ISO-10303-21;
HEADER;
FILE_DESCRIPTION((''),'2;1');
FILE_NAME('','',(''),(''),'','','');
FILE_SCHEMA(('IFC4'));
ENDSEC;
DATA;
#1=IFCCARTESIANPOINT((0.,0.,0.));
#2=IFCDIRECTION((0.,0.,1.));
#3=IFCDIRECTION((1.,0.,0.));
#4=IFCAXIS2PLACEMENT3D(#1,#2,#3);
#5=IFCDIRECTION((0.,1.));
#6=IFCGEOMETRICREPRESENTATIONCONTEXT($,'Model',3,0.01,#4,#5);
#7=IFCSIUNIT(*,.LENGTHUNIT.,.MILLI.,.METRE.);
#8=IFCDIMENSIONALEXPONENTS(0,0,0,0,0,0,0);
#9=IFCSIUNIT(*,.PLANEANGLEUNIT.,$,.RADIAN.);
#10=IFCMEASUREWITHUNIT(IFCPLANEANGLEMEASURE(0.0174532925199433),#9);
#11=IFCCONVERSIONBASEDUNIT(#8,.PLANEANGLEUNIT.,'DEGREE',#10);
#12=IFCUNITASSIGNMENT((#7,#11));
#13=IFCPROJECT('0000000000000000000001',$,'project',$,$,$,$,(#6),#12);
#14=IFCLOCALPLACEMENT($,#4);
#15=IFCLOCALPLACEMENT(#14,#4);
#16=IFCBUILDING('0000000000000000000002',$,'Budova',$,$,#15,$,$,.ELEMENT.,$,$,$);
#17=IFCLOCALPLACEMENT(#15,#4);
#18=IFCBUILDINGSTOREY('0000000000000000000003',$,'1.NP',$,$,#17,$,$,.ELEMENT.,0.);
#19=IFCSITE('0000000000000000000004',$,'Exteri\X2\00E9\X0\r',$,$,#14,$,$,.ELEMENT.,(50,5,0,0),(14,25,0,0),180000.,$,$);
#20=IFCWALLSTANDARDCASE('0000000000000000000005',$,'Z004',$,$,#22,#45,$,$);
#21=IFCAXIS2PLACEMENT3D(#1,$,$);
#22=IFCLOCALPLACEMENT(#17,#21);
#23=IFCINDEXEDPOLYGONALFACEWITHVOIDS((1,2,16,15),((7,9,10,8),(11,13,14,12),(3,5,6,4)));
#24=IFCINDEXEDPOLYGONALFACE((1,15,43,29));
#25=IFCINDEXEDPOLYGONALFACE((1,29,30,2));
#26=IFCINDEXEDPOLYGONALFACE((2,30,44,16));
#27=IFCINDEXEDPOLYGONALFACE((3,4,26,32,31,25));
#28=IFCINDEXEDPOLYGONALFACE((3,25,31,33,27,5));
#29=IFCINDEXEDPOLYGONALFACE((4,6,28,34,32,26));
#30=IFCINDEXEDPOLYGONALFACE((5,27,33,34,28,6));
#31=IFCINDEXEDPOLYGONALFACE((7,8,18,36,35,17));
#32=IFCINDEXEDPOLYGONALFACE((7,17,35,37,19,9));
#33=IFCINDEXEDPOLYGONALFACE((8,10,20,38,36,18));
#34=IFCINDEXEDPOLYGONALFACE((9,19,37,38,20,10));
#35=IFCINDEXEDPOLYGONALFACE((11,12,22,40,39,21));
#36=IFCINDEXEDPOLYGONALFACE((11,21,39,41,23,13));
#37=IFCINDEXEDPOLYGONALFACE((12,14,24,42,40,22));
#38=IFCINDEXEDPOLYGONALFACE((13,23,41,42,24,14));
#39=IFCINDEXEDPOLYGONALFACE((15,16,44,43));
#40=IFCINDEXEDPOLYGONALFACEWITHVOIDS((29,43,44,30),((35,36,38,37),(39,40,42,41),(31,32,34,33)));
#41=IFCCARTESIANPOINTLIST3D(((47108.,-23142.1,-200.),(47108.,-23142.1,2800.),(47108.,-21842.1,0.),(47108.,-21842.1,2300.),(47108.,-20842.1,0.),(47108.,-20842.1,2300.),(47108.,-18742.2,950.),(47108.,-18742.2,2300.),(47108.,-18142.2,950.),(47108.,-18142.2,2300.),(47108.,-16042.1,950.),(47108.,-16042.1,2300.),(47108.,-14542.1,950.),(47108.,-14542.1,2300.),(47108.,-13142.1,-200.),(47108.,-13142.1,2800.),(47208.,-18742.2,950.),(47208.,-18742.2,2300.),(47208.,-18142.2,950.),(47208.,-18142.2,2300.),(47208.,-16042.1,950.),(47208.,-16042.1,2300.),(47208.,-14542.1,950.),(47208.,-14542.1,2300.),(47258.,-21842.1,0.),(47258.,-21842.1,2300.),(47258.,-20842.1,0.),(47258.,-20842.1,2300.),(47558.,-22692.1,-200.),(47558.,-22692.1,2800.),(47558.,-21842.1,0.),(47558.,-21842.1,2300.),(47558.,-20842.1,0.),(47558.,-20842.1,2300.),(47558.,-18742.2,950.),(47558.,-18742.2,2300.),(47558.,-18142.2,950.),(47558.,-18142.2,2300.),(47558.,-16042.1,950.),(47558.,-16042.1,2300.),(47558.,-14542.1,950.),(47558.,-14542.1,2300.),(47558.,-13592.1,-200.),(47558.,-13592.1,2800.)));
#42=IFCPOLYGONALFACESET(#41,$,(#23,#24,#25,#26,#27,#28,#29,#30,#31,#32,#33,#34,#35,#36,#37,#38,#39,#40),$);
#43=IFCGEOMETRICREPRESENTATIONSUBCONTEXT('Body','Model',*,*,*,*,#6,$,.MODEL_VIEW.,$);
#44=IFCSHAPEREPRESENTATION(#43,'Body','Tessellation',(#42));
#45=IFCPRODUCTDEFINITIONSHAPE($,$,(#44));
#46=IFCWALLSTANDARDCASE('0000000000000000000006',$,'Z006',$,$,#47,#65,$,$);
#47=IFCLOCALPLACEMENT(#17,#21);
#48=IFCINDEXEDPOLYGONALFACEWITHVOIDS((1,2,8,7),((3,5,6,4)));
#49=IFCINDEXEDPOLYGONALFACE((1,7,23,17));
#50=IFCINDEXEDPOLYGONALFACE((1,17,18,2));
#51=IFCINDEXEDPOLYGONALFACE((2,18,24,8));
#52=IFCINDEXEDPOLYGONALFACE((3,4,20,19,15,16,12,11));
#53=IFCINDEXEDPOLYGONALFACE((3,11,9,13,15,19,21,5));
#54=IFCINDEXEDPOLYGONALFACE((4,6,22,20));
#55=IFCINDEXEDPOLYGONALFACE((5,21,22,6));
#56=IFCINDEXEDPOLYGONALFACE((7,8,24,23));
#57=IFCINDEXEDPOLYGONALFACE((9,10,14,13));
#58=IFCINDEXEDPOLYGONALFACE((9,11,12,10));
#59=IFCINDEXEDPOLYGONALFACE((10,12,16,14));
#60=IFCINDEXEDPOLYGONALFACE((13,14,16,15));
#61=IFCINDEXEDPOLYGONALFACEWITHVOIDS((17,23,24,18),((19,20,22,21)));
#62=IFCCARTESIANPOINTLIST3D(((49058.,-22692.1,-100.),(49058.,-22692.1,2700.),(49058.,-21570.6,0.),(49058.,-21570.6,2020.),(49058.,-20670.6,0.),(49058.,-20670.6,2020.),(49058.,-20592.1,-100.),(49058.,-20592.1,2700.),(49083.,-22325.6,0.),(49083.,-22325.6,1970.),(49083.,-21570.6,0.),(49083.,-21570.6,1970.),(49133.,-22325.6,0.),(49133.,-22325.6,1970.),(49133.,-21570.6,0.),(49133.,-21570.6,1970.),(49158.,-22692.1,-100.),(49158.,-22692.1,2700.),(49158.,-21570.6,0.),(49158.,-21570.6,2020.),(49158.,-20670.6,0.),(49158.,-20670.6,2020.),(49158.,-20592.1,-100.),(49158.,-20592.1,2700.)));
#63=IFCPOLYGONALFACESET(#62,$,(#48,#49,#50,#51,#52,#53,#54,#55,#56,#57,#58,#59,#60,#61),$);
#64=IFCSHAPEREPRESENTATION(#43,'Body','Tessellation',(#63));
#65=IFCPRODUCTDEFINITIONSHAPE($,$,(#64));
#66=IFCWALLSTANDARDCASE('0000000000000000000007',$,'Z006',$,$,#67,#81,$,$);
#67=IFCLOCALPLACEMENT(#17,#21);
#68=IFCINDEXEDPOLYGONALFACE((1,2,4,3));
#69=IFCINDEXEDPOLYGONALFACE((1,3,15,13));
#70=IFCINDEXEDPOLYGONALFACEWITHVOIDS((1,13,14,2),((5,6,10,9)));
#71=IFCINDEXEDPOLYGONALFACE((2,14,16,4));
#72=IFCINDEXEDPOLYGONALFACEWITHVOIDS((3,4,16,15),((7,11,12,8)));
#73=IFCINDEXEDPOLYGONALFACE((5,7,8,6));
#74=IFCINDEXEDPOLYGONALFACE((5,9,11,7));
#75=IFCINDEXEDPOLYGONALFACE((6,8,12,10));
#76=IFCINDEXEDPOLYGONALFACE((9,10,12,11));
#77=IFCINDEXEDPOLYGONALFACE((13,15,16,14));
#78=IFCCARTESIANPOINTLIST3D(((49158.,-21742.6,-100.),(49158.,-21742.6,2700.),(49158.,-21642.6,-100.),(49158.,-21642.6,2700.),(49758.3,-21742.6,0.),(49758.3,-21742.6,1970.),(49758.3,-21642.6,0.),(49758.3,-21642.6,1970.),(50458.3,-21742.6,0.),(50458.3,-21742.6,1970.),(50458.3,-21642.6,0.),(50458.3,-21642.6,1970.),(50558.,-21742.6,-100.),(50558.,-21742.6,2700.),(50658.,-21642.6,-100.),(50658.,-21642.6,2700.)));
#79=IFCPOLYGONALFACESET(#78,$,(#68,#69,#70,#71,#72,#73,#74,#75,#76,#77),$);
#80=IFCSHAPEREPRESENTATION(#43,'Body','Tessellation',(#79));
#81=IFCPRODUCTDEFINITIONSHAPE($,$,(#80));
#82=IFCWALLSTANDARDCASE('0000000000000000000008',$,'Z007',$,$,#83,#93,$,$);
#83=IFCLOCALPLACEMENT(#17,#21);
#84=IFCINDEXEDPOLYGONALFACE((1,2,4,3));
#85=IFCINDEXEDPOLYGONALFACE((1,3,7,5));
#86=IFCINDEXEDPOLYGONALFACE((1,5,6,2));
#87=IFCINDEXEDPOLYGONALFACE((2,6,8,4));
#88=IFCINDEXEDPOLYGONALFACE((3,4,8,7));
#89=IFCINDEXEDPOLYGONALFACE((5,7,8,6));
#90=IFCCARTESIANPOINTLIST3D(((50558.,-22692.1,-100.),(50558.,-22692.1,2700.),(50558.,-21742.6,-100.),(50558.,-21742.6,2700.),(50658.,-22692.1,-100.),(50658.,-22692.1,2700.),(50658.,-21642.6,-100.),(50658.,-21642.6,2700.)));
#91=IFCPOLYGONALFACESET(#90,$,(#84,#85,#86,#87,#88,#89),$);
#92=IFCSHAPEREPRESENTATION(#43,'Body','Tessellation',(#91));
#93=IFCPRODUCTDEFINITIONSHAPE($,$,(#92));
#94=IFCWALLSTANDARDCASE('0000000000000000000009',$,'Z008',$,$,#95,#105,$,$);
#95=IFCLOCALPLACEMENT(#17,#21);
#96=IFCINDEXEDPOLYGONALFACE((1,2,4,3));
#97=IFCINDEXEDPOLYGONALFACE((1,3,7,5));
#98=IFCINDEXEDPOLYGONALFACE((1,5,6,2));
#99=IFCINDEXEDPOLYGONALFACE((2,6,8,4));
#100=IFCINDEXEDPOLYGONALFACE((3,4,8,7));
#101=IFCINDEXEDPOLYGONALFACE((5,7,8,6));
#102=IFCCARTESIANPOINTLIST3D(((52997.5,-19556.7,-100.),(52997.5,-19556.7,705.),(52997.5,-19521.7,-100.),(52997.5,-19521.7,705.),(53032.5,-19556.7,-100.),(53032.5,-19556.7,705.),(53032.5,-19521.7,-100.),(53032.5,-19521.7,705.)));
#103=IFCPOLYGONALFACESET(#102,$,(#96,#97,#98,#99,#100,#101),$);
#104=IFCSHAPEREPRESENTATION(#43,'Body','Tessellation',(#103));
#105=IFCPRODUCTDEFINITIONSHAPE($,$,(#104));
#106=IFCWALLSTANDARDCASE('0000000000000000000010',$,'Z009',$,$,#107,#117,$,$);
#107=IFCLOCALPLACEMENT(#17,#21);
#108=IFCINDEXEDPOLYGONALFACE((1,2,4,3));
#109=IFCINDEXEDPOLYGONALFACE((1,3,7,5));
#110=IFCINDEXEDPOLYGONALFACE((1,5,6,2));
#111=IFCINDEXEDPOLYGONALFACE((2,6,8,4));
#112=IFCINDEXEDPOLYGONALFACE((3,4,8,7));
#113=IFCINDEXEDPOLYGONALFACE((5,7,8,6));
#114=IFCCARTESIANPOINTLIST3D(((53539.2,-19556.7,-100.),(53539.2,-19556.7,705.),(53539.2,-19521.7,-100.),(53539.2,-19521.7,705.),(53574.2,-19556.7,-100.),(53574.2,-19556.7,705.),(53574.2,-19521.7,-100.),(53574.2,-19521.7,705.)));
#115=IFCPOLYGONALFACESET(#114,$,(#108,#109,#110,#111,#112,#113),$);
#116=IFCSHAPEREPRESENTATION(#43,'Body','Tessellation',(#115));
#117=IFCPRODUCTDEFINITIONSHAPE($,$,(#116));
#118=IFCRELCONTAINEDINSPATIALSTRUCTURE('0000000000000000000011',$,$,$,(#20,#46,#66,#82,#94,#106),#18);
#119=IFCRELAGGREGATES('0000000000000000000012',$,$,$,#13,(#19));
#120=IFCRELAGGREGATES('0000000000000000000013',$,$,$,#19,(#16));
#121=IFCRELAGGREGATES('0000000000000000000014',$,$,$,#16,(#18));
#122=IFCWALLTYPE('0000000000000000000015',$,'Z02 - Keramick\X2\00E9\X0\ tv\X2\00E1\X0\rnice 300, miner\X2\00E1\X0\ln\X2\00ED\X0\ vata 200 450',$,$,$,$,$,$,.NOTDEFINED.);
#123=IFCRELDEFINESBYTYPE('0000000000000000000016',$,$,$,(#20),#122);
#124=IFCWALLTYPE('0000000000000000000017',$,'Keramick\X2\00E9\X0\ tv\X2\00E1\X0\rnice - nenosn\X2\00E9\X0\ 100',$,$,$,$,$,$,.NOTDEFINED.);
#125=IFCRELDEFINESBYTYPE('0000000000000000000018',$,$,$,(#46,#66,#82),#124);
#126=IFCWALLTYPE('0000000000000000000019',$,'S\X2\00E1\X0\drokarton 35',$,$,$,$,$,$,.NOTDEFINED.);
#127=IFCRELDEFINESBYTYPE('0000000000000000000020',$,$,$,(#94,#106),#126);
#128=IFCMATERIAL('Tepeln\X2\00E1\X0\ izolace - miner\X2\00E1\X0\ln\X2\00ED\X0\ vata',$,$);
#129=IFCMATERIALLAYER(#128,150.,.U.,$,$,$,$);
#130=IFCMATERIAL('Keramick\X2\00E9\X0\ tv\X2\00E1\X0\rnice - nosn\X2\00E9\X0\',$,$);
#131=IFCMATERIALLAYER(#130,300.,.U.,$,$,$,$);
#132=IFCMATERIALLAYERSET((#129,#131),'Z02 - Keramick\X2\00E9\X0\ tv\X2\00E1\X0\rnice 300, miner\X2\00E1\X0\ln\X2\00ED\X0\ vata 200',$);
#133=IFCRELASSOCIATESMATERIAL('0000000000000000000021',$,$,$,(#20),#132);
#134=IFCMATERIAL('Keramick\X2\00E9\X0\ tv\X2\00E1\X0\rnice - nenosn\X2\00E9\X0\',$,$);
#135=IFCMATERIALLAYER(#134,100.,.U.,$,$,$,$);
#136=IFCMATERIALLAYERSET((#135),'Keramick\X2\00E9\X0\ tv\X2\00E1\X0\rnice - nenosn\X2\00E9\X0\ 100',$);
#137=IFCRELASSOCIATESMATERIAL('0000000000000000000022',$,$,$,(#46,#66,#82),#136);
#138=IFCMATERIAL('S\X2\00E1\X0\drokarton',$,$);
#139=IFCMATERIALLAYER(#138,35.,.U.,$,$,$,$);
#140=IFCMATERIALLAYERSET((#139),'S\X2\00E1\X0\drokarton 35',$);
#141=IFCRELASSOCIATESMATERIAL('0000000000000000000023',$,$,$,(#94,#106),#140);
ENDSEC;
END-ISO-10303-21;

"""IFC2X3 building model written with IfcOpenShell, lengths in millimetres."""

from ifc_helpers import new_model, entity, si_unit, converted_unit, direction, frame, origin_with_axes, origin_2d_with_axis, place, context, subcontext, project, spatial, polyline, rectangle, outline, extrude, material, layer, layer_set, layer_usage, type_object, element, save


model = new_model("IFC2X3")

# Units and contexts
model_context = context("Model", 3, precision=0.01, world=origin_with_axes(), true_north=direction((0.0, 1.0)))
body_context = subcontext(model_context, "Body", "Model", "MODEL_VIEW")
ifc_project = project(units=[si_unit("LENGTHUNIT", "METRE", prefix="MILLI"), converted_unit("PLANEANGLEUNIT", "DEGREE", entity("IfcPlaneAngleMeasure", 0.0174532925199433), si_unit("PLANEANGLEUNIT", "RADIAN"), dimensions=[0, 0, 0, 0, 0, 0, 0])], contexts=[model_context])

# Site, building, storey
site_placement = place(None, origin_with_axes())
site = spatial("IfcSite", under=ifc_project, at=site_placement, Name="Exteriér", CompositionType="ELEMENT", RefLatitude=(50, 5, 0, 0), RefLongitude=(14, 25, 0, 0), RefElevation=180000.0)
building_placement = place(site_placement, origin_with_axes())
building = spatial("IfcBuilding", under=site, at=building_placement, Name="Budova", CompositionType="ELEMENT")
storey_placement = place(building_placement, origin_with_axes())
storey = spatial("IfcBuildingStorey", under=building, at=storey_placement, Name="1.NP", CompositionType="ELEMENT", Elevation=0.0)

# Wall, openings
ifc_material_1 = material(Name="Tepelná izolace - minerální vata")
ifc_layer_1 = layer(ifc_material_1, 150.0, ventilated="UNKNOWN")
ifc_material_2 = material(Name="Keramické tvárnice - nosné")
ifc_layer_2 = layer(ifc_material_2, 300.0, ventilated="UNKNOWN")
ifc_layer_set_1 = layer_set([ifc_layer_1, ifc_layer_2], Name="Z02 - Keramické tvárnice 300, minerální vata 200")
ifc_layer_usage_1 = layer_usage(ifc_layer_set_1, "AXIS2", "NEGATIVE", 0.0)
wall_type_1 = type_object("IfcWallType", Name="Z02 - Keramické tvárnice 300, minerální vata 200 450", PredefinedType="NOTDEFINED")
wall_1_placement = place(storey_placement, frame((47108.0, -23142.1, -200.0), z_axis=(0.0, 0.0, 1.0), x_axis=(0.0, 1.0, 0.0)))
wall_1 = element("IfcWallStandardCase", 1, at=wall_1_placement, inside=storey, type_object=wall_type_1, material=ifc_layer_usage_1, Name="Z004", context=body_context, shape_type="SweptSolid", body=[
    extrude(outline(polyline([(450.0, -450.0), (9550.0, -450.0), (10000.0, 0.0), (0.0, 0.0), (450.0, -450.0)])), origin_with_axes(), (0.0, 0.0, 1.0), 3000.0),
])
opening_1_placement = place(wall_1_placement, frame((4699.8, 0.0, 1150.0), z_axis=(0.0, 0.0, 1.0), x_axis=(1.0, 0.0, 0.0)))
element("IfcOpeningElement", 2, at=opening_1_placement, cuts=wall_1, context=body_context, shape_type="SweptSolid", body=[
    extrude(rectangle(XDim=600.0, YDim=1350.0, at=origin_2d_with_axis()), frame((0.0, -100.0, 675.0), z_axis=(0.0, 1.0, 0.0), x_axis=(-1.0, 0.0, 0.0)), (0.0, 0.0, -1.0), 800.0),
    extrude(rectangle(XDim=600.0, YDim=1350.0, at=origin_2d_with_axis()), frame((0.0, -100.0, 675.0), z_axis=(0.0, -1.0, 0.0), x_axis=(-1.0, 0.0, 0.0)), (0.0, 0.0, -1.0), 550.0),
])
opening_2_placement = place(wall_1_placement, frame((1800.0, 0.0, 200.0), z_axis=(0.0, 0.0, 1.0), x_axis=(1.0, 0.0, 0.0)))
element("IfcOpeningElement", 3, at=opening_2_placement, cuts=wall_1, context=body_context, shape_type="SweptSolid", body=[
    extrude(rectangle(XDim=1000.0, YDim=2300.0, at=origin_2d_with_axis()), frame((0.0, -150.0, 1150.0), z_axis=(0.0, -1.0, 0.0), x_axis=(1.0, 0.0, 0.0)), (0.0, 0.0, 1.0), 750.0),
    extrude(rectangle(XDim=1000.0, YDim=2300.0, at=origin_2d_with_axis()), frame((0.0, -150.0, 1150.0), z_axis=(0.0, 1.0, 0.0), x_axis=(1.0, 0.0, 0.0)), (0.0, 0.0, 1.0), 600.0),
])
opening_3_placement = place(wall_1_placement, frame((7850.0, 0.0, 1150.0), z_axis=(0.0, 0.0, 1.0), x_axis=(1.0, 0.0, 0.0)))
element("IfcOpeningElement", 4, at=opening_3_placement, cuts=wall_1, context=body_context, shape_type="SweptSolid", body=[
    extrude(rectangle(XDim=1500.0, YDim=1350.0, at=origin_2d_with_axis()), frame((0.0, -100.0, 675.0), z_axis=(0.0, -1.0, 0.0), x_axis=(1.0, 0.0, 0.0)), (0.0, 0.0, 1.0), 800.0),
    extrude(rectangle(XDim=1500.0, YDim=1350.0, at=origin_2d_with_axis()), frame((0.0, -100.0, 675.0), z_axis=(0.0, 1.0, 0.0), x_axis=(1.0, 0.0, 0.0)), (0.0, 0.0, 1.0), 550.0),
])
ifc_material_3 = material(Name="Keramické tvárnice - nenosné")
ifc_layer_3 = layer(ifc_material_3, 100.0, ventilated="UNKNOWN")
ifc_layer_set_2 = layer_set([ifc_layer_3], Name="Keramické tvárnice - nenosné 100")
wall_type_2 = type_object("IfcWallType", Name="Keramické tvárnice - nenosné 100", PredefinedType="NOTDEFINED")

# Walls, openings
ifc_layer_usage_2 = layer_usage(ifc_layer_set_2, "AXIS2", "POSITIVE", 0.0)
wall_2_placement = place(storey_placement, frame((49158.0, -23142.1, -100.0), z_axis=(0.0, 0.0, 1.0), x_axis=(0.0, 1.0, 0.0)))
wall_2 = element("IfcWallStandardCase", 5, at=wall_2_placement, inside=storey, type_object=wall_type_2, material=ifc_layer_usage_2, Name="Z006", context=body_context, shape_type="SweptSolid", body=[
    extrude(outline(polyline([(450.0, 0.0), (2550.0, 0.0), (2550.0, 100.0), (450.0, 100.0), (450.0, 0.0)])), origin_with_axes(), (0.0, 0.0, 1.0), 2800.0),
])
opening_4_placement = place(wall_2_placement, frame((2021.5, 0.0, 100.0), z_axis=(0.0, 0.0, 1.0), x_axis=(1.0, 0.0, 0.0)))
element("IfcOpeningElement", 6, at=opening_4_placement, cuts=wall_2, context=body_context, shape_type="SweptSolid", body=[
    extrude(rectangle(XDim=900.0, YDim=2020.0, at=origin_2d_with_axis()), frame((0.0, 100.0, 1010.0), z_axis=(0.0, 1.0, 0.0), x_axis=(-1.0, 0.0, 0.0)), (0.0, 0.0, -1.0), 300.0),
    extrude(rectangle(XDim=755.0, YDim=1970.0, at=origin_2d_with_axis()), frame((-827.5, 75.0, 985.0), z_axis=(0.0, 1.0, 0.0), x_axis=(-1.0, 0.0, 0.0)), (0.0, 0.0, -1.0), 50.0),
])
ifc_layer_usage_3 = layer_usage(ifc_layer_set_2, "AXIS2", "NEGATIVE", 0.0)
wall_3_placement = place(storey_placement, frame((49158.0, -21642.6, -100.0), z_axis=(0.0, 0.0, 1.0), x_axis=(1.0, 0.0, 0.0)))
wall_3 = element("IfcWallStandardCase", 7, at=wall_3_placement, inside=storey, type_object=wall_type_2, material=ifc_layer_usage_3, Name="Z006", context=body_context, shape_type="SweptSolid", body=[
    extrude(outline(polyline([(0.0, -100.0), (1400.0, -100.0), (1500.0, 0.0), (0.0, 0.0), (0.0, -100.0)])), origin_with_axes(), (0.0, 0.0, 1.0), 2800.0),
])
opening_5_placement = place(wall_3_placement, frame((950.3, 0.0, 100.0), z_axis=(0.0, 0.0, 1.0), x_axis=(1.0, 0.0, 0.0)))
element("IfcOpeningElement", 8, at=opening_5_placement, cuts=wall_3, context=body_context, shape_type="SweptSolid", body=[
    extrude(rectangle(XDim=700.0, YDim=1970.0, at=origin_2d_with_axis()), frame((0.0, -100.0, 985.0), z_axis=(0.0, 1.0, 0.0), x_axis=(-1.0, 0.0, 0.0)), (0.0, 0.0, 1.0), 300.0),
])

# Walls
ifc_layer_usage_4 = layer_usage(ifc_layer_set_2, "AXIS2", "NEGATIVE", 0.0)
wall_4_placement = place(storey_placement, frame((50658.0, -21642.6, -100.0), z_axis=(0.0, 0.0, 1.0), x_axis=(0.0, -1.0, 0.0)))
element("IfcWallStandardCase", 9, at=wall_4_placement, inside=storey, type_object=wall_type_2, material=ifc_layer_usage_4, Name="Z007", context=body_context, shape_type="SweptSolid", body=[
    extrude(outline(polyline([(100.0, -100.0), (1049.5, -100.0), (1049.5, 0.0), (0.0, 0.0), (100.0, -100.0)])), origin_with_axes(), (0.0, 0.0, 1.0), 2800.0),
])
ifc_material_4 = material(Name="Sádrokarton")
ifc_layer_4 = layer(ifc_material_4, 35.0, ventilated="UNKNOWN")
ifc_layer_set_3 = layer_set([ifc_layer_4], Name="Sádrokarton 35")
ifc_layer_usage_5 = layer_usage(ifc_layer_set_3, "AXIS2", "NEGATIVE", 0.0)
wall_type_3 = type_object("IfcWallType", Name="Sádrokarton 35", PredefinedType="NOTDEFINED")
wall_5_placement = place(storey_placement, frame((52997.5, -19556.7, -100.0), z_axis=(0.0, 0.0, 1.0), x_axis=(0.0, 1.0, 0.0)))
element("IfcWallStandardCase", 10, at=wall_5_placement, inside=storey, type_object=wall_type_3, material=ifc_layer_usage_5, Name="Z008", context=body_context, shape_type="SweptSolid", body=[
    extrude(outline(polyline([(0.0, -35.0), (35.0, -35.0), (35.0, 0.0), (0.0, 0.0), (0.0, -35.0)])), origin_with_axes(), (0.0, 0.0, 1.0), 805.0),
])
ifc_layer_usage_6 = layer_usage(ifc_layer_set_3, "AXIS2", "POSITIVE", 0.0)
wall_6_placement = place(storey_placement, frame((53574.2, -19556.7, -100.0), z_axis=(0.0, 0.0, 1.0), x_axis=(0.0, 1.0, 0.0)))
element("IfcWallStandardCase", 11, at=wall_6_placement, inside=storey, type_object=wall_type_3, material=ifc_layer_usage_6, Name="Z009", context=body_context, shape_type="SweptSolid", body=[
    extrude(outline(polyline([(0.0, 0.0), (35.0, 0.0), (35.0, 35.0), (0.0, 35.0), (0.0, 0.0)])), origin_with_axes(), (0.0, 0.0, 1.0), 805.0),
])

save(model, "model.ifc")
